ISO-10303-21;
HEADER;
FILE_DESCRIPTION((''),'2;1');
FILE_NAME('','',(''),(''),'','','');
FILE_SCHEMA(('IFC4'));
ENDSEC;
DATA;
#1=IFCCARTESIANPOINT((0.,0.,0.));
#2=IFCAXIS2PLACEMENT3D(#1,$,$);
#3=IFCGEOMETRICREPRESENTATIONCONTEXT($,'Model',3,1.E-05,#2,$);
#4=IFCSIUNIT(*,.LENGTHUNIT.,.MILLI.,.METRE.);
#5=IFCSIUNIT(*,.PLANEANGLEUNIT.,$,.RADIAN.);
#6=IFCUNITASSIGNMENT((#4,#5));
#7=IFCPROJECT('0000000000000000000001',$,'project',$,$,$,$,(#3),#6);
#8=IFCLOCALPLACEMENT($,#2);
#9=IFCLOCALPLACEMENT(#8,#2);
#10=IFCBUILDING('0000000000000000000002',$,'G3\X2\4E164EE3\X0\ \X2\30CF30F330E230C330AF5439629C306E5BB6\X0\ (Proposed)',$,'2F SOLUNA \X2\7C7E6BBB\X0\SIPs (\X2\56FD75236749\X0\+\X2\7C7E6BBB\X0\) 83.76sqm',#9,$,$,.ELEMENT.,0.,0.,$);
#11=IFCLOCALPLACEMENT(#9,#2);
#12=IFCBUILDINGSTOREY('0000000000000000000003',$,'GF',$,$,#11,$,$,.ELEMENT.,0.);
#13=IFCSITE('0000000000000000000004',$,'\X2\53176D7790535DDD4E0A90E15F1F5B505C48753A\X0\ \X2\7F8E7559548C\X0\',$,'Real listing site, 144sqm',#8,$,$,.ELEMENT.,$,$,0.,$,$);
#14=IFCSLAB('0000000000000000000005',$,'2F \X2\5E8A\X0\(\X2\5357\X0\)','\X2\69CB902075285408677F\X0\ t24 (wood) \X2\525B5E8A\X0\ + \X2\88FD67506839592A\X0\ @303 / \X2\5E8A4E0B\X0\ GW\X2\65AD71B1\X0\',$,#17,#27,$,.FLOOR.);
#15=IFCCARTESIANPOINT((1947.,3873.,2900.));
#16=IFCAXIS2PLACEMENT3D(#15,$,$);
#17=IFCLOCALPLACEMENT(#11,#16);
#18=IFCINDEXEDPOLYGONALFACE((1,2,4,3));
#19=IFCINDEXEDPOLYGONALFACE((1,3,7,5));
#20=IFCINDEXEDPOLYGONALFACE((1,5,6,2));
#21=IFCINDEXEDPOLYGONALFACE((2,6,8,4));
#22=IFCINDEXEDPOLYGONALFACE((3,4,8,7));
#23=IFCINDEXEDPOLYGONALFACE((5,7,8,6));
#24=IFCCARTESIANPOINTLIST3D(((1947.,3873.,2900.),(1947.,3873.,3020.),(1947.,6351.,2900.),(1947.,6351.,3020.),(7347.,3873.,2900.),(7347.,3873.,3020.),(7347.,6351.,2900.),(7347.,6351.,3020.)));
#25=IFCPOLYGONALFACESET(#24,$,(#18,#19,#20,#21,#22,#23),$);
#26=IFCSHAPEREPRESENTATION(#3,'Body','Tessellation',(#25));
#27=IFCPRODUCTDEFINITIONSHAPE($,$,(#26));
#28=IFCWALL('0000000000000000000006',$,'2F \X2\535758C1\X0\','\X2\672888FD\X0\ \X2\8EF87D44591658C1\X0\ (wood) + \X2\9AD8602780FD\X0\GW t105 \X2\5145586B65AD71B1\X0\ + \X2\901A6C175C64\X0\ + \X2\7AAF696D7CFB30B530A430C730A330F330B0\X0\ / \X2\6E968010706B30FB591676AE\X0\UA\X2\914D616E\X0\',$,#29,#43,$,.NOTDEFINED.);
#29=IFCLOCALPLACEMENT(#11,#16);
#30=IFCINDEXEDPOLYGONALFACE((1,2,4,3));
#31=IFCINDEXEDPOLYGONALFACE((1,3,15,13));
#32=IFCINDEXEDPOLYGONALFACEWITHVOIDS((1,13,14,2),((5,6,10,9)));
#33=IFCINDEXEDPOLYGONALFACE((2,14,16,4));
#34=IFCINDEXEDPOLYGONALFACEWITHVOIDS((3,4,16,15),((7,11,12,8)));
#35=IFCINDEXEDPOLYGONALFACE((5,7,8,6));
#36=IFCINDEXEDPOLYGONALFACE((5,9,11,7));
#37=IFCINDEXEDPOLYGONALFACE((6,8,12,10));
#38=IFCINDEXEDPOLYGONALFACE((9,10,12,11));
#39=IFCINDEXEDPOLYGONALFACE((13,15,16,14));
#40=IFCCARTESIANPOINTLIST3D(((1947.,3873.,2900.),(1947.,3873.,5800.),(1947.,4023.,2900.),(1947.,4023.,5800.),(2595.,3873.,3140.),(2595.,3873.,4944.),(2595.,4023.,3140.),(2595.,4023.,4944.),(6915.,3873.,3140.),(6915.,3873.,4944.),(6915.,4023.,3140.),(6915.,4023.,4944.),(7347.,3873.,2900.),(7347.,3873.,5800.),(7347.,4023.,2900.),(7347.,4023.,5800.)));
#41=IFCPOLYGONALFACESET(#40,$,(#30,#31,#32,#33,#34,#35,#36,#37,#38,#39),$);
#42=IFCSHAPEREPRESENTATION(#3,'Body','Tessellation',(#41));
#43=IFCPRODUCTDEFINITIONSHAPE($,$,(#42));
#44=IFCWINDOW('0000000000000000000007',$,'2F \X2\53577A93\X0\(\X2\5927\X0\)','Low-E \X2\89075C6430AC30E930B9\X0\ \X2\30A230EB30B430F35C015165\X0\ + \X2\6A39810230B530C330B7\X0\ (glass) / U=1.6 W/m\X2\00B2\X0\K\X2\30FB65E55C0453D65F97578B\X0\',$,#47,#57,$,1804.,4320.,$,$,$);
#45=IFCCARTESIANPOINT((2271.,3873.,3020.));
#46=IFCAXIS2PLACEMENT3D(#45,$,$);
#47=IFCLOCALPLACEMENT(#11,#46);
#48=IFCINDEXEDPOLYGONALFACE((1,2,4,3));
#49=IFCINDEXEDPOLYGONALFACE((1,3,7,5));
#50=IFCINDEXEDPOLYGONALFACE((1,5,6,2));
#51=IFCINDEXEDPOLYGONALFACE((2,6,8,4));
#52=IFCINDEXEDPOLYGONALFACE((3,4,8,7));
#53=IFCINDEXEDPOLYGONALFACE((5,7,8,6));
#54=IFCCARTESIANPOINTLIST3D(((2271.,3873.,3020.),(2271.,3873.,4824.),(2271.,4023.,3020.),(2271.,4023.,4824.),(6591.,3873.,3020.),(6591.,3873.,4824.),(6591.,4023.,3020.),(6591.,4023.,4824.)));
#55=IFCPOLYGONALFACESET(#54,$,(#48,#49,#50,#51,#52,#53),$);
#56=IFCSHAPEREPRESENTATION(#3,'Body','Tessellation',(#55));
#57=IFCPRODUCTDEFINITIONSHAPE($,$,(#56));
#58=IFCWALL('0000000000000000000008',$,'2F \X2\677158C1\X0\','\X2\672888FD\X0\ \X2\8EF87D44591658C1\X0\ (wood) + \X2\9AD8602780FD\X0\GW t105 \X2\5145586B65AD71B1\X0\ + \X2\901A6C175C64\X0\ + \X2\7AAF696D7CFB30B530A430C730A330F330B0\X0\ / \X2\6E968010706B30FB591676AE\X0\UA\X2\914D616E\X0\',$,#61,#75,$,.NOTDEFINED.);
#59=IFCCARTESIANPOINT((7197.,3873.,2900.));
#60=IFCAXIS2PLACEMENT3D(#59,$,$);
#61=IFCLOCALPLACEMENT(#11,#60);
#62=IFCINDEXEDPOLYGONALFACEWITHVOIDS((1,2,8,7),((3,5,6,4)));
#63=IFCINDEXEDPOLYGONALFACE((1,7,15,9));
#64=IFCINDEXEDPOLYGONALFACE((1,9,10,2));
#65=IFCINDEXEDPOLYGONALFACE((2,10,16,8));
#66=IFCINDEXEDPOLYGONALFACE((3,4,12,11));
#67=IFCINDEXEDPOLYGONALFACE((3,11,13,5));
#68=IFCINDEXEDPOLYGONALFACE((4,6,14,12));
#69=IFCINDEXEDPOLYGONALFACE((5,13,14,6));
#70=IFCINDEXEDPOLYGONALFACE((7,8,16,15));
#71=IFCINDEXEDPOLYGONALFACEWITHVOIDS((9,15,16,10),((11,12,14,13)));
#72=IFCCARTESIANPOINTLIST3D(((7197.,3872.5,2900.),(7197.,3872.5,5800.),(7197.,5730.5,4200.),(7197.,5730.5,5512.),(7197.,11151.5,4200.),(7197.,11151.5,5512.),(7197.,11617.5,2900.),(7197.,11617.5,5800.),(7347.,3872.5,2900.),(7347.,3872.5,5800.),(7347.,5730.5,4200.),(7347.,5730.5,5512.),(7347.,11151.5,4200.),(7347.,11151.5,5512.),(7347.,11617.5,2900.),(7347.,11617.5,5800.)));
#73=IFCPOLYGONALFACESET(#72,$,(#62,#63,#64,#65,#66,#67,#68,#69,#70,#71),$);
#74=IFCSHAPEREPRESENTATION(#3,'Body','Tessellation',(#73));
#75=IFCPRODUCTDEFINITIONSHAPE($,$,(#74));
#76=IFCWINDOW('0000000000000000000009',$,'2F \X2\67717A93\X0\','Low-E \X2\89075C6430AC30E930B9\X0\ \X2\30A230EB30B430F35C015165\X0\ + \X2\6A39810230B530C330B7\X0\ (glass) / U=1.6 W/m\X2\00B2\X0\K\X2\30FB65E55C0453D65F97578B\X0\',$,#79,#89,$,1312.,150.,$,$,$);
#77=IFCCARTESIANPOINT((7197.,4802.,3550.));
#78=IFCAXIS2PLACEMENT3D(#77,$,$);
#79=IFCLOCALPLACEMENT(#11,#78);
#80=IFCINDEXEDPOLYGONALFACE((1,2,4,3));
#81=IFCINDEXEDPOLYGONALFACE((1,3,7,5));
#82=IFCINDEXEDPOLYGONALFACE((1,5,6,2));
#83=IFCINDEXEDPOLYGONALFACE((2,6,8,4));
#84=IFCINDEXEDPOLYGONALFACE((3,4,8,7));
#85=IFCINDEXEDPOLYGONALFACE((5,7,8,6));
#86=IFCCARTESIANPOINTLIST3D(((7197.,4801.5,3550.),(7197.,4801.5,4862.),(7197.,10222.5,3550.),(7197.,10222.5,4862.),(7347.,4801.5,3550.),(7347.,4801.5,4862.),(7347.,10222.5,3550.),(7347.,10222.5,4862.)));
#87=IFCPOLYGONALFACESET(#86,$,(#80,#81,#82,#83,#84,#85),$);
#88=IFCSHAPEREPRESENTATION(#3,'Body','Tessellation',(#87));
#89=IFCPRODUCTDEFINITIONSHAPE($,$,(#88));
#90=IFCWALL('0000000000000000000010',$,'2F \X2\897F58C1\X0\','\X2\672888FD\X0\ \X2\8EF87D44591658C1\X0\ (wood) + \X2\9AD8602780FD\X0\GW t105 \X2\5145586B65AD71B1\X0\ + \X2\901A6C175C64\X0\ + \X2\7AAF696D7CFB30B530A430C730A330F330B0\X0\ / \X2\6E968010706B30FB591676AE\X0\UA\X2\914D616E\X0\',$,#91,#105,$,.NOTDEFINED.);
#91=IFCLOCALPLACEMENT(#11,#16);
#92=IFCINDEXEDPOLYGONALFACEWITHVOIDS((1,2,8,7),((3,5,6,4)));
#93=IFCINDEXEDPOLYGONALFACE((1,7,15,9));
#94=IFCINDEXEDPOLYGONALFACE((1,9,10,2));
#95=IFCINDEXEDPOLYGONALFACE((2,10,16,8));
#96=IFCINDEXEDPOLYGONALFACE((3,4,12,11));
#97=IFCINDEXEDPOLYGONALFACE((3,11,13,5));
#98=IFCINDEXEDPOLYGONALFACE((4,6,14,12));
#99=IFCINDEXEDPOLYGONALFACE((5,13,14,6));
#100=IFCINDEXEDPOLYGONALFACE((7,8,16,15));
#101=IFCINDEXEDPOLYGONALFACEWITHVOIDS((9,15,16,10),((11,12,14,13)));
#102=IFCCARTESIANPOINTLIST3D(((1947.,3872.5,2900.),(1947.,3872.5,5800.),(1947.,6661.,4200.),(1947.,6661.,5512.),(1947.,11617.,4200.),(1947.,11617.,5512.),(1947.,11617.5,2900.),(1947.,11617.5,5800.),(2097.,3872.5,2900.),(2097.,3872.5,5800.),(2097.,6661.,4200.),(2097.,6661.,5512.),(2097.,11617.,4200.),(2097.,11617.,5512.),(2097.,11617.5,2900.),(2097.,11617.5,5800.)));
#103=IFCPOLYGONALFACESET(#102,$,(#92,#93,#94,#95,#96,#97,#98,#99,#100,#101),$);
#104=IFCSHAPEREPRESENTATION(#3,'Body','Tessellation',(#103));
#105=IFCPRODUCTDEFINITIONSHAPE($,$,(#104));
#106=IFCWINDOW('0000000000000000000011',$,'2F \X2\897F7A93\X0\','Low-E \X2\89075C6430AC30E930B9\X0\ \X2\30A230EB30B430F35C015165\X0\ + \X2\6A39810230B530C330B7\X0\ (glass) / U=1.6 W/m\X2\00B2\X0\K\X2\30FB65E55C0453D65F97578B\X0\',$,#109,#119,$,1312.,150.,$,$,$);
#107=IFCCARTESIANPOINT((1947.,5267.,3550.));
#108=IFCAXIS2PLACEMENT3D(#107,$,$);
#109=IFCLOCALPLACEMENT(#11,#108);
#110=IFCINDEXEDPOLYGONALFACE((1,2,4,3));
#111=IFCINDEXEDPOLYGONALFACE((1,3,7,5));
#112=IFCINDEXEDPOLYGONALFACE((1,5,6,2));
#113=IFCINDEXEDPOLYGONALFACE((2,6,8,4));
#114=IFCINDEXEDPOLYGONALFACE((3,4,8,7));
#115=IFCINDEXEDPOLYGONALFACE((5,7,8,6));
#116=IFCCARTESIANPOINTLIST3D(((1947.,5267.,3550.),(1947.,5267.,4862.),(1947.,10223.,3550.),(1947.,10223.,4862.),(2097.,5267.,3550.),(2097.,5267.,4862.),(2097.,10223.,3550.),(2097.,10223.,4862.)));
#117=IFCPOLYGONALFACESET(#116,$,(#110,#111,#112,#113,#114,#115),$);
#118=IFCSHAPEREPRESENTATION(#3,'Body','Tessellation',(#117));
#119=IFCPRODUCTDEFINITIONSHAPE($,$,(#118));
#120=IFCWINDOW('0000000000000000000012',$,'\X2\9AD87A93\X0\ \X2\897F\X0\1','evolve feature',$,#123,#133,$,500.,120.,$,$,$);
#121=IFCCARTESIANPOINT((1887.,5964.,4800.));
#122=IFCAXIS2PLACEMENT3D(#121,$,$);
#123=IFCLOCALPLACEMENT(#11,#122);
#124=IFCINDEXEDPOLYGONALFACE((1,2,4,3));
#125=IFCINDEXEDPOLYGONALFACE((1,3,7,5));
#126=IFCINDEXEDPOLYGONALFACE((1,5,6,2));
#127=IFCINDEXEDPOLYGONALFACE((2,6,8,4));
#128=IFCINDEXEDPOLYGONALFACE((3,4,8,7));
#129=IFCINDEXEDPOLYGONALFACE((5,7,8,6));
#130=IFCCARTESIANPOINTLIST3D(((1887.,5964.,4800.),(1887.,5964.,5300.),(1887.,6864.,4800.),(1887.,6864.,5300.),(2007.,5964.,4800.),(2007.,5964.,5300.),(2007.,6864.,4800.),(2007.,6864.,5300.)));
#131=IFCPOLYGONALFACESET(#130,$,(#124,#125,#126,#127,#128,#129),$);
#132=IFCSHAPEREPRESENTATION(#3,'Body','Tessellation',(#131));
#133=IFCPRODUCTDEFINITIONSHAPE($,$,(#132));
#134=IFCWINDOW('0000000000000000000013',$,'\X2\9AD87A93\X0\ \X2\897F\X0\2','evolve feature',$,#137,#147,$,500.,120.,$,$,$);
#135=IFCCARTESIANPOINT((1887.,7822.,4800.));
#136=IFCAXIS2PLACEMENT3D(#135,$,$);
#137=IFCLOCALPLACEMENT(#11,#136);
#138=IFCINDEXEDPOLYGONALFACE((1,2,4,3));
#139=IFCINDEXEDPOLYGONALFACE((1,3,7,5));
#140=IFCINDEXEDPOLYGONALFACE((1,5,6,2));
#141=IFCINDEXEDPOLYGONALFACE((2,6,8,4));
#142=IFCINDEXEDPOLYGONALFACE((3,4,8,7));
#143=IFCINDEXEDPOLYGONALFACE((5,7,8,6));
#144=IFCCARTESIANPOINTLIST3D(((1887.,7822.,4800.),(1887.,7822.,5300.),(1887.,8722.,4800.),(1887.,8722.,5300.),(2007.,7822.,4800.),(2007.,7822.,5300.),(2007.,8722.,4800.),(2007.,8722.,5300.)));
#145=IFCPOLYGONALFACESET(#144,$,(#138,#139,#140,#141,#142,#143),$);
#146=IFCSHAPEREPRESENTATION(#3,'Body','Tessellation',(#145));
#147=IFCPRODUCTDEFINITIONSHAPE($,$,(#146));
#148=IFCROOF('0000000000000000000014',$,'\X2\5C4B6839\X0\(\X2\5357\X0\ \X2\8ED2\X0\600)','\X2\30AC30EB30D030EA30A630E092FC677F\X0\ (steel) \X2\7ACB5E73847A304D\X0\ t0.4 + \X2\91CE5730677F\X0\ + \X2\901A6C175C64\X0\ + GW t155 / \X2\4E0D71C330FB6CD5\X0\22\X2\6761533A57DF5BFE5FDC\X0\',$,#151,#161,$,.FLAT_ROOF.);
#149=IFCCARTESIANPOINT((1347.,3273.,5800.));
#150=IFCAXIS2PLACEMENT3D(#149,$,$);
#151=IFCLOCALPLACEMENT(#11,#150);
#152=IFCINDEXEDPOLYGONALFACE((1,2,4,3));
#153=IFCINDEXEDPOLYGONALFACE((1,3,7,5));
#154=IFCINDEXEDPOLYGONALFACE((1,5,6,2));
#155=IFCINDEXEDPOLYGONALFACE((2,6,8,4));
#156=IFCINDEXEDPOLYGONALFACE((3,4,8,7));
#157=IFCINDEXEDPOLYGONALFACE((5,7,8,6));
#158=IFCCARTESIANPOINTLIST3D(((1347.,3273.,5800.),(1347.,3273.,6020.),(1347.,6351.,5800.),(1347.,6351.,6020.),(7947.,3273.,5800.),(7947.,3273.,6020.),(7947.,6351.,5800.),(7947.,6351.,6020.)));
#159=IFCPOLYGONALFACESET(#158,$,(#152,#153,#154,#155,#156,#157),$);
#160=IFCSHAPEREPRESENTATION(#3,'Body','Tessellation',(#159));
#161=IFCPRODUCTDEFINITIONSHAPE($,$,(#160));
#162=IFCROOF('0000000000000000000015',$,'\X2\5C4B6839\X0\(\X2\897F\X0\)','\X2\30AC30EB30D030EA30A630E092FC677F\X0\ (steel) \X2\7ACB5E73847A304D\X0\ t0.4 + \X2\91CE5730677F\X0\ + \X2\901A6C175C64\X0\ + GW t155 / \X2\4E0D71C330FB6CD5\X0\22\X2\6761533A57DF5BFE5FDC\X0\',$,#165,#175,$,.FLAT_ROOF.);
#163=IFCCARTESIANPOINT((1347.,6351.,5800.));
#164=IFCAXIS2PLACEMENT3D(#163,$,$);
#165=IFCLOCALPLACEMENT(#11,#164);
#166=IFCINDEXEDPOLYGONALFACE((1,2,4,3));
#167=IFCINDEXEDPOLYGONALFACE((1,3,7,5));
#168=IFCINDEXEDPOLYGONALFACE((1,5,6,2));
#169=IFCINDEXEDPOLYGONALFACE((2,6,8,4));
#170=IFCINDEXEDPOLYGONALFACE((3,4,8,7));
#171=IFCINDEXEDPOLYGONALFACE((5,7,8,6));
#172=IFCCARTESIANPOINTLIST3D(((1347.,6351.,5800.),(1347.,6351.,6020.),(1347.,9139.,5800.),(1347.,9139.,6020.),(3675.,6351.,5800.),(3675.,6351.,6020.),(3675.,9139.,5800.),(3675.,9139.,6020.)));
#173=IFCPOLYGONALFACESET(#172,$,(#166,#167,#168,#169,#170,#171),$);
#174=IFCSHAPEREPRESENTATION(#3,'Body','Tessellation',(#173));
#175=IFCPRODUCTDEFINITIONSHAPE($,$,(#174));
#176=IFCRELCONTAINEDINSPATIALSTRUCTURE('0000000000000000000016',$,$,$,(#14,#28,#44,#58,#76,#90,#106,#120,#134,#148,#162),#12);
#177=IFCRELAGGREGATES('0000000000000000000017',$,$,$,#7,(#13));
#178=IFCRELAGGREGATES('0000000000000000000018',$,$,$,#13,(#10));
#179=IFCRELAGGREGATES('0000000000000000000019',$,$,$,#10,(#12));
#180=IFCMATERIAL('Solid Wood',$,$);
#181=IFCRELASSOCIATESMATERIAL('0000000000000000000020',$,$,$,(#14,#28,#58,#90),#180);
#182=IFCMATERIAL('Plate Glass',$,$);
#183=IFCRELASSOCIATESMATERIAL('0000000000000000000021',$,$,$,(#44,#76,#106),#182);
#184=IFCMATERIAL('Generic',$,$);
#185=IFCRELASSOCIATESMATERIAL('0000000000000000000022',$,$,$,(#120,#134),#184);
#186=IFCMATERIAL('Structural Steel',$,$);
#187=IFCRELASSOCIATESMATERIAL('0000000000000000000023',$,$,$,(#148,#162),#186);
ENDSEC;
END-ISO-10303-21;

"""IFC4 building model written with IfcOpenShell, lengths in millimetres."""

from ifc_helpers import new_model, si_unit, frame, frame_2d, origin, place, context, project, spatial, rectangle, extrude, material, element, fill, save


model = new_model("IFC4")

# Units and contexts
model_context = context("Model", 3, precision=1e-05, world=origin())
ifc_project = project(units=[si_unit("LENGTHUNIT", "METRE", prefix="MILLI"), si_unit("PLANEANGLEUNIT", "RADIAN")], contexts=[model_context])

# Site, building, storey
site_placement = place(None, origin())
site = spatial("IfcSite", under=ifc_project, at=site_placement, Name="北海道川上郡弟子屈町 美留和", ObjectType="Real listing site, 144sqm", CompositionType="ELEMENT", RefElevation=0.0)
building_placement = place(site_placement, origin())
building = spatial("IfcBuilding", under=site, at=building_placement, Name="G3世代 ハンモック吹抜の家 (Proposed)", ObjectType="2F SOLUNA 籾殻SIPs (国産杉+籾殻) 83.76sqm", CompositionType="ELEMENT", ElevationOfRefHeight=0.0, ElevationOfTerrain=0.0)
storey_placement = place(building_placement, origin())
storey = spatial("IfcBuildingStorey", under=building, at=storey_placement, Name="GF", CompositionType="ELEMENT", Elevation=0.0)

# Slab
ifc_material_1 = material(Name="Solid Wood")
slab_placement = place(storey_placement, frame((1947.0, 3873.0, 2900.0)))
element("IfcSlab", 1, at=slab_placement, inside=storey, material=ifc_material_1, Name="2F 床(南)", Description="構造用合板 t24 (wood) 剛床 + 製材根太 @303 / 床下 GW断熱", PredefinedType="FLOOR", context=model_context, shape_type="SweptSolid", body=[
    extrude(rectangle(XDim=5400.0, YDim=2478.0, at=frame_2d((2700.0, 1239.0))), frame((1947.0, 3873.0, 2900.0)), (0.0, 0.0, 1.0), 120.0),
])

# Walls, openings, windows
wall_1_placement = place(storey_placement, frame((1947.0, 3873.0, 2900.0)))
wall_1 = element("IfcWall", 2, at=wall_1_placement, inside=storey, material=ifc_material_1, Name="2F 南壁", Description="木製 軸組外壁 (wood) + 高性能GW t105 充填断熱 + 通気層 + 窯業系サイディング / 準耐火・外皮UA配慮", PredefinedType="NOTDEFINED", context=model_context, shape_type="SweptSolid", body=[
    extrude(rectangle(XDim=5400.0, YDim=150.0, at=frame_2d((2700.0, 75.0))), frame((1947.0, 3873.0, 2900.0)), (0.0, 0.0, 1.0), 2900.0),
])
opening_1_placement = place(storey_placement, frame((2271.0, 3873.0, 3020.0)))
opening_1 = element("IfcOpeningElement", 3, at=opening_1_placement, cuts=wall_1, PredefinedType="NOTDEFINED", context=model_context, shape_type="SweptSolid", body=[
    extrude(rectangle(XDim=4320.0, YDim=150.0, at=frame_2d((2160.0, 75.0))), frame((2271.0, 3873.0, 3020.0)), (0.0, 0.0, 1.0), 1804.0),
])
ifc_material_2 = material(Name="Plate Glass")
window_1_placement = place(storey_placement, frame((2271.0, 3873.0, 3020.0)))
window_1 = element("IfcWindow", 4, at=window_1_placement, inside=storey, material=ifc_material_2, Name="2F 南窓(大)", Description="Low-E 複層ガラス アルゴン封入 + 樹脂サッシ (glass) / U=1.6 W/m²K・日射取得型", OverallHeight=1804.0, OverallWidth=4320.0, context=model_context, shape_type="SweptSolid", body=[
    extrude(rectangle(XDim=4320.0, YDim=150.0, at=frame_2d((2160.0, 75.0))), frame((2271.0, 3873.0, 3020.0)), (0.0, 0.0, 1.0), 1804.0),
])
fill(opening_1, window_1)
wall_2_placement = place(storey_placement, frame((7197.0, 3873.0, 2900.0)))
wall_2 = element("IfcWall", 5, at=wall_2_placement, inside=storey, material=ifc_material_1, Name="2F 東壁", Description="木製 軸組外壁 (wood) + 高性能GW t105 充填断熱 + 通気層 + 窯業系サイディング / 準耐火・外皮UA配慮", PredefinedType="NOTDEFINED", context=model_context, shape_type="SweptSolid", body=[
    extrude(rectangle(XDim=150.0, YDim=7745.0, at=frame_2d((75.0, 3872.0))), frame((7197.0, 3873.0, 2900.0)), (0.0, 0.0, 1.0), 2900.0),
])
opening_2_placement = place(storey_placement, frame((7197.0, 4802.0, 3550.0)))
opening_2 = element("IfcOpeningElement", 6, at=opening_2_placement, cuts=wall_2, PredefinedType="NOTDEFINED", context=model_context, shape_type="SweptSolid", body=[
    extrude(rectangle(XDim=150.0, YDim=5421.0, at=frame_2d((75.0, 2710.0))), frame((7197.0, 4802.0, 3550.0)), (0.0, 0.0, 1.0), 1312.0),
])
window_2_placement = place(storey_placement, frame((7197.0, 4802.0, 3550.0)))
window_2 = element("IfcWindow", 7, at=window_2_placement, inside=storey, material=ifc_material_2, Name="2F 東窓", Description="Low-E 複層ガラス アルゴン封入 + 樹脂サッシ (glass) / U=1.6 W/m²K・日射取得型", OverallHeight=1312.0, OverallWidth=150.0, context=model_context, shape_type="SweptSolid", body=[
    extrude(rectangle(XDim=150.0, YDim=5421.0, at=frame_2d((75.0, 2710.0))), frame((7197.0, 4802.0, 3550.0)), (0.0, 0.0, 1.0), 1312.0),
])
fill(opening_2, window_2)

# Wall, openings, windows
wall_3_placement = place(storey_placement, frame((1947.0, 3873.0, 2900.0)))
wall_3 = element("IfcWall", 8, at=wall_3_placement, inside=storey, material=ifc_material_1, Name="2F 西壁", Description="木製 軸組外壁 (wood) + 高性能GW t105 充填断熱 + 通気層 + 窯業系サイディング / 準耐火・外皮UA配慮", PredefinedType="NOTDEFINED", context=model_context, shape_type="SweptSolid", body=[
    extrude(rectangle(XDim=150.0, YDim=7745.0, at=frame_2d((75.0, 3872.0))), frame((1947.0, 3873.0, 2900.0)), (0.0, 0.0, 1.0), 2900.0),
])
opening_3_placement = place(storey_placement, frame((1947.0, 5267.0, 3550.0)))
opening_3 = element("IfcOpeningElement", 9, at=opening_3_placement, cuts=wall_3, PredefinedType="NOTDEFINED", context=model_context, shape_type="SweptSolid", body=[
    extrude(rectangle(XDim=150.0, YDim=4956.0, at=frame_2d((75.0, 2478.0))), frame((1947.0, 5267.0, 3550.0)), (0.0, 0.0, 1.0), 1312.0),
])
opening_4_placement = place(storey_placement, frame((1887.0, 5964.0, 4800.0)))
opening_4 = element("IfcOpeningElement", 10, at=opening_4_placement, cuts=wall_3, PredefinedType="NOTDEFINED", context=model_context, shape_type="SweptSolid", body=[
    extrude(rectangle(XDim=120.0, YDim=900.0, at=frame_2d((60.0, 450.0))), frame((1887.0, 5964.0, 4800.0)), (0.0, 0.0, 1.0), 500.0),
])
opening_5_placement = place(storey_placement, frame((1887.0, 7822.0, 4800.0)))
opening_5 = element("IfcOpeningElement", 11, at=opening_5_placement, cuts=wall_3, PredefinedType="NOTDEFINED", context=model_context, shape_type="SweptSolid", body=[
    extrude(rectangle(XDim=120.0, YDim=900.0, at=frame_2d((60.0, 450.0))), frame((1887.0, 7822.0, 4800.0)), (0.0, 0.0, 1.0), 500.0),
])
window_3_placement = place(storey_placement, frame((1947.0, 5267.0, 3550.0)))
window_3 = element("IfcWindow", 12, at=window_3_placement, inside=storey, material=ifc_material_2, Name="2F 西窓", Description="Low-E 複層ガラス アルゴン封入 + 樹脂サッシ (glass) / U=1.6 W/m²K・日射取得型", OverallHeight=1312.0, OverallWidth=150.0, context=model_context, shape_type="SweptSolid", body=[
    extrude(rectangle(XDim=150.0, YDim=4956.0, at=frame_2d((75.0, 2478.0))), frame((1947.0, 5267.0, 3550.0)), (0.0, 0.0, 1.0), 1312.0),
])
fill(opening_3, window_3)
ifc_material_3 = material(Name="Generic")
window_4_placement = place(storey_placement, frame((1887.0, 5964.0, 4800.0)))
window_4 = element("IfcWindow", 13, at=window_4_placement, inside=storey, material=ifc_material_3, Name="高窓 西1", Description="evolve feature", OverallHeight=500.0, OverallWidth=120.0, context=model_context, shape_type="SweptSolid", body=[
    extrude(rectangle(XDim=120.0, YDim=900.0, at=frame_2d((60.0, 450.0))), frame((1887.0, 5964.0, 4800.0)), (0.0, 0.0, 1.0), 500.0),
])
fill(opening_4, window_4)
window_5_placement = place(storey_placement, frame((1887.0, 7822.0, 4800.0)))
window_5 = element("IfcWindow", 14, at=window_5_placement, inside=storey, material=ifc_material_3, Name="高窓 西2", Description="evolve feature", OverallHeight=500.0, OverallWidth=120.0, context=model_context, shape_type="SweptSolid", body=[
    extrude(rectangle(XDim=120.0, YDim=900.0, at=frame_2d((60.0, 450.0))), frame((1887.0, 7822.0, 4800.0)), (0.0, 0.0, 1.0), 500.0),
])
fill(opening_5, window_5)

# Roofs
ifc_material_4 = material(Name="Structural Steel")
roof_1_placement = place(storey_placement, frame((1347.0, 3273.0, 5800.0)))
element("IfcRoof", 15, at=roof_1_placement, inside=storey, material=ifc_material_4, Name="屋根(南 軒600)", Description="ガルバリウム鋼板 (steel) 立平葺き t0.4 + 野地板 + 通気層 + GW t155 / 不燃・法22条区域対応", PredefinedType="FLAT_ROOF", context=model_context, shape_type="SweptSolid", body=[
    extrude(rectangle(XDim=6600.0, YDim=3078.0, at=frame_2d((3300.0, 1539.0))), frame((1347.0, 3273.0, 5800.0)), (0.0, 0.0, 1.0), 220.0),
])
roof_2_placement = place(storey_placement, frame((1347.0, 6351.0, 5800.0)))
element("IfcRoof", 16, at=roof_2_placement, inside=storey, material=ifc_material_4, Name="屋根(西)", Description="ガルバリウム鋼板 (steel) 立平葺き t0.4 + 野地板 + 通気層 + GW t155 / 不燃・法22条区域対応", PredefinedType="FLAT_ROOF", context=model_context, shape_type="SweptSolid", body=[
    extrude(rectangle(XDim=2328.0, YDim=2788.0, at=frame_2d((1164.0, 1394.0))), frame((1347.0, 6351.0, 5800.0)), (0.0, 0.0, 1.0), 220.0),
])

save(model, "model.ifc")
